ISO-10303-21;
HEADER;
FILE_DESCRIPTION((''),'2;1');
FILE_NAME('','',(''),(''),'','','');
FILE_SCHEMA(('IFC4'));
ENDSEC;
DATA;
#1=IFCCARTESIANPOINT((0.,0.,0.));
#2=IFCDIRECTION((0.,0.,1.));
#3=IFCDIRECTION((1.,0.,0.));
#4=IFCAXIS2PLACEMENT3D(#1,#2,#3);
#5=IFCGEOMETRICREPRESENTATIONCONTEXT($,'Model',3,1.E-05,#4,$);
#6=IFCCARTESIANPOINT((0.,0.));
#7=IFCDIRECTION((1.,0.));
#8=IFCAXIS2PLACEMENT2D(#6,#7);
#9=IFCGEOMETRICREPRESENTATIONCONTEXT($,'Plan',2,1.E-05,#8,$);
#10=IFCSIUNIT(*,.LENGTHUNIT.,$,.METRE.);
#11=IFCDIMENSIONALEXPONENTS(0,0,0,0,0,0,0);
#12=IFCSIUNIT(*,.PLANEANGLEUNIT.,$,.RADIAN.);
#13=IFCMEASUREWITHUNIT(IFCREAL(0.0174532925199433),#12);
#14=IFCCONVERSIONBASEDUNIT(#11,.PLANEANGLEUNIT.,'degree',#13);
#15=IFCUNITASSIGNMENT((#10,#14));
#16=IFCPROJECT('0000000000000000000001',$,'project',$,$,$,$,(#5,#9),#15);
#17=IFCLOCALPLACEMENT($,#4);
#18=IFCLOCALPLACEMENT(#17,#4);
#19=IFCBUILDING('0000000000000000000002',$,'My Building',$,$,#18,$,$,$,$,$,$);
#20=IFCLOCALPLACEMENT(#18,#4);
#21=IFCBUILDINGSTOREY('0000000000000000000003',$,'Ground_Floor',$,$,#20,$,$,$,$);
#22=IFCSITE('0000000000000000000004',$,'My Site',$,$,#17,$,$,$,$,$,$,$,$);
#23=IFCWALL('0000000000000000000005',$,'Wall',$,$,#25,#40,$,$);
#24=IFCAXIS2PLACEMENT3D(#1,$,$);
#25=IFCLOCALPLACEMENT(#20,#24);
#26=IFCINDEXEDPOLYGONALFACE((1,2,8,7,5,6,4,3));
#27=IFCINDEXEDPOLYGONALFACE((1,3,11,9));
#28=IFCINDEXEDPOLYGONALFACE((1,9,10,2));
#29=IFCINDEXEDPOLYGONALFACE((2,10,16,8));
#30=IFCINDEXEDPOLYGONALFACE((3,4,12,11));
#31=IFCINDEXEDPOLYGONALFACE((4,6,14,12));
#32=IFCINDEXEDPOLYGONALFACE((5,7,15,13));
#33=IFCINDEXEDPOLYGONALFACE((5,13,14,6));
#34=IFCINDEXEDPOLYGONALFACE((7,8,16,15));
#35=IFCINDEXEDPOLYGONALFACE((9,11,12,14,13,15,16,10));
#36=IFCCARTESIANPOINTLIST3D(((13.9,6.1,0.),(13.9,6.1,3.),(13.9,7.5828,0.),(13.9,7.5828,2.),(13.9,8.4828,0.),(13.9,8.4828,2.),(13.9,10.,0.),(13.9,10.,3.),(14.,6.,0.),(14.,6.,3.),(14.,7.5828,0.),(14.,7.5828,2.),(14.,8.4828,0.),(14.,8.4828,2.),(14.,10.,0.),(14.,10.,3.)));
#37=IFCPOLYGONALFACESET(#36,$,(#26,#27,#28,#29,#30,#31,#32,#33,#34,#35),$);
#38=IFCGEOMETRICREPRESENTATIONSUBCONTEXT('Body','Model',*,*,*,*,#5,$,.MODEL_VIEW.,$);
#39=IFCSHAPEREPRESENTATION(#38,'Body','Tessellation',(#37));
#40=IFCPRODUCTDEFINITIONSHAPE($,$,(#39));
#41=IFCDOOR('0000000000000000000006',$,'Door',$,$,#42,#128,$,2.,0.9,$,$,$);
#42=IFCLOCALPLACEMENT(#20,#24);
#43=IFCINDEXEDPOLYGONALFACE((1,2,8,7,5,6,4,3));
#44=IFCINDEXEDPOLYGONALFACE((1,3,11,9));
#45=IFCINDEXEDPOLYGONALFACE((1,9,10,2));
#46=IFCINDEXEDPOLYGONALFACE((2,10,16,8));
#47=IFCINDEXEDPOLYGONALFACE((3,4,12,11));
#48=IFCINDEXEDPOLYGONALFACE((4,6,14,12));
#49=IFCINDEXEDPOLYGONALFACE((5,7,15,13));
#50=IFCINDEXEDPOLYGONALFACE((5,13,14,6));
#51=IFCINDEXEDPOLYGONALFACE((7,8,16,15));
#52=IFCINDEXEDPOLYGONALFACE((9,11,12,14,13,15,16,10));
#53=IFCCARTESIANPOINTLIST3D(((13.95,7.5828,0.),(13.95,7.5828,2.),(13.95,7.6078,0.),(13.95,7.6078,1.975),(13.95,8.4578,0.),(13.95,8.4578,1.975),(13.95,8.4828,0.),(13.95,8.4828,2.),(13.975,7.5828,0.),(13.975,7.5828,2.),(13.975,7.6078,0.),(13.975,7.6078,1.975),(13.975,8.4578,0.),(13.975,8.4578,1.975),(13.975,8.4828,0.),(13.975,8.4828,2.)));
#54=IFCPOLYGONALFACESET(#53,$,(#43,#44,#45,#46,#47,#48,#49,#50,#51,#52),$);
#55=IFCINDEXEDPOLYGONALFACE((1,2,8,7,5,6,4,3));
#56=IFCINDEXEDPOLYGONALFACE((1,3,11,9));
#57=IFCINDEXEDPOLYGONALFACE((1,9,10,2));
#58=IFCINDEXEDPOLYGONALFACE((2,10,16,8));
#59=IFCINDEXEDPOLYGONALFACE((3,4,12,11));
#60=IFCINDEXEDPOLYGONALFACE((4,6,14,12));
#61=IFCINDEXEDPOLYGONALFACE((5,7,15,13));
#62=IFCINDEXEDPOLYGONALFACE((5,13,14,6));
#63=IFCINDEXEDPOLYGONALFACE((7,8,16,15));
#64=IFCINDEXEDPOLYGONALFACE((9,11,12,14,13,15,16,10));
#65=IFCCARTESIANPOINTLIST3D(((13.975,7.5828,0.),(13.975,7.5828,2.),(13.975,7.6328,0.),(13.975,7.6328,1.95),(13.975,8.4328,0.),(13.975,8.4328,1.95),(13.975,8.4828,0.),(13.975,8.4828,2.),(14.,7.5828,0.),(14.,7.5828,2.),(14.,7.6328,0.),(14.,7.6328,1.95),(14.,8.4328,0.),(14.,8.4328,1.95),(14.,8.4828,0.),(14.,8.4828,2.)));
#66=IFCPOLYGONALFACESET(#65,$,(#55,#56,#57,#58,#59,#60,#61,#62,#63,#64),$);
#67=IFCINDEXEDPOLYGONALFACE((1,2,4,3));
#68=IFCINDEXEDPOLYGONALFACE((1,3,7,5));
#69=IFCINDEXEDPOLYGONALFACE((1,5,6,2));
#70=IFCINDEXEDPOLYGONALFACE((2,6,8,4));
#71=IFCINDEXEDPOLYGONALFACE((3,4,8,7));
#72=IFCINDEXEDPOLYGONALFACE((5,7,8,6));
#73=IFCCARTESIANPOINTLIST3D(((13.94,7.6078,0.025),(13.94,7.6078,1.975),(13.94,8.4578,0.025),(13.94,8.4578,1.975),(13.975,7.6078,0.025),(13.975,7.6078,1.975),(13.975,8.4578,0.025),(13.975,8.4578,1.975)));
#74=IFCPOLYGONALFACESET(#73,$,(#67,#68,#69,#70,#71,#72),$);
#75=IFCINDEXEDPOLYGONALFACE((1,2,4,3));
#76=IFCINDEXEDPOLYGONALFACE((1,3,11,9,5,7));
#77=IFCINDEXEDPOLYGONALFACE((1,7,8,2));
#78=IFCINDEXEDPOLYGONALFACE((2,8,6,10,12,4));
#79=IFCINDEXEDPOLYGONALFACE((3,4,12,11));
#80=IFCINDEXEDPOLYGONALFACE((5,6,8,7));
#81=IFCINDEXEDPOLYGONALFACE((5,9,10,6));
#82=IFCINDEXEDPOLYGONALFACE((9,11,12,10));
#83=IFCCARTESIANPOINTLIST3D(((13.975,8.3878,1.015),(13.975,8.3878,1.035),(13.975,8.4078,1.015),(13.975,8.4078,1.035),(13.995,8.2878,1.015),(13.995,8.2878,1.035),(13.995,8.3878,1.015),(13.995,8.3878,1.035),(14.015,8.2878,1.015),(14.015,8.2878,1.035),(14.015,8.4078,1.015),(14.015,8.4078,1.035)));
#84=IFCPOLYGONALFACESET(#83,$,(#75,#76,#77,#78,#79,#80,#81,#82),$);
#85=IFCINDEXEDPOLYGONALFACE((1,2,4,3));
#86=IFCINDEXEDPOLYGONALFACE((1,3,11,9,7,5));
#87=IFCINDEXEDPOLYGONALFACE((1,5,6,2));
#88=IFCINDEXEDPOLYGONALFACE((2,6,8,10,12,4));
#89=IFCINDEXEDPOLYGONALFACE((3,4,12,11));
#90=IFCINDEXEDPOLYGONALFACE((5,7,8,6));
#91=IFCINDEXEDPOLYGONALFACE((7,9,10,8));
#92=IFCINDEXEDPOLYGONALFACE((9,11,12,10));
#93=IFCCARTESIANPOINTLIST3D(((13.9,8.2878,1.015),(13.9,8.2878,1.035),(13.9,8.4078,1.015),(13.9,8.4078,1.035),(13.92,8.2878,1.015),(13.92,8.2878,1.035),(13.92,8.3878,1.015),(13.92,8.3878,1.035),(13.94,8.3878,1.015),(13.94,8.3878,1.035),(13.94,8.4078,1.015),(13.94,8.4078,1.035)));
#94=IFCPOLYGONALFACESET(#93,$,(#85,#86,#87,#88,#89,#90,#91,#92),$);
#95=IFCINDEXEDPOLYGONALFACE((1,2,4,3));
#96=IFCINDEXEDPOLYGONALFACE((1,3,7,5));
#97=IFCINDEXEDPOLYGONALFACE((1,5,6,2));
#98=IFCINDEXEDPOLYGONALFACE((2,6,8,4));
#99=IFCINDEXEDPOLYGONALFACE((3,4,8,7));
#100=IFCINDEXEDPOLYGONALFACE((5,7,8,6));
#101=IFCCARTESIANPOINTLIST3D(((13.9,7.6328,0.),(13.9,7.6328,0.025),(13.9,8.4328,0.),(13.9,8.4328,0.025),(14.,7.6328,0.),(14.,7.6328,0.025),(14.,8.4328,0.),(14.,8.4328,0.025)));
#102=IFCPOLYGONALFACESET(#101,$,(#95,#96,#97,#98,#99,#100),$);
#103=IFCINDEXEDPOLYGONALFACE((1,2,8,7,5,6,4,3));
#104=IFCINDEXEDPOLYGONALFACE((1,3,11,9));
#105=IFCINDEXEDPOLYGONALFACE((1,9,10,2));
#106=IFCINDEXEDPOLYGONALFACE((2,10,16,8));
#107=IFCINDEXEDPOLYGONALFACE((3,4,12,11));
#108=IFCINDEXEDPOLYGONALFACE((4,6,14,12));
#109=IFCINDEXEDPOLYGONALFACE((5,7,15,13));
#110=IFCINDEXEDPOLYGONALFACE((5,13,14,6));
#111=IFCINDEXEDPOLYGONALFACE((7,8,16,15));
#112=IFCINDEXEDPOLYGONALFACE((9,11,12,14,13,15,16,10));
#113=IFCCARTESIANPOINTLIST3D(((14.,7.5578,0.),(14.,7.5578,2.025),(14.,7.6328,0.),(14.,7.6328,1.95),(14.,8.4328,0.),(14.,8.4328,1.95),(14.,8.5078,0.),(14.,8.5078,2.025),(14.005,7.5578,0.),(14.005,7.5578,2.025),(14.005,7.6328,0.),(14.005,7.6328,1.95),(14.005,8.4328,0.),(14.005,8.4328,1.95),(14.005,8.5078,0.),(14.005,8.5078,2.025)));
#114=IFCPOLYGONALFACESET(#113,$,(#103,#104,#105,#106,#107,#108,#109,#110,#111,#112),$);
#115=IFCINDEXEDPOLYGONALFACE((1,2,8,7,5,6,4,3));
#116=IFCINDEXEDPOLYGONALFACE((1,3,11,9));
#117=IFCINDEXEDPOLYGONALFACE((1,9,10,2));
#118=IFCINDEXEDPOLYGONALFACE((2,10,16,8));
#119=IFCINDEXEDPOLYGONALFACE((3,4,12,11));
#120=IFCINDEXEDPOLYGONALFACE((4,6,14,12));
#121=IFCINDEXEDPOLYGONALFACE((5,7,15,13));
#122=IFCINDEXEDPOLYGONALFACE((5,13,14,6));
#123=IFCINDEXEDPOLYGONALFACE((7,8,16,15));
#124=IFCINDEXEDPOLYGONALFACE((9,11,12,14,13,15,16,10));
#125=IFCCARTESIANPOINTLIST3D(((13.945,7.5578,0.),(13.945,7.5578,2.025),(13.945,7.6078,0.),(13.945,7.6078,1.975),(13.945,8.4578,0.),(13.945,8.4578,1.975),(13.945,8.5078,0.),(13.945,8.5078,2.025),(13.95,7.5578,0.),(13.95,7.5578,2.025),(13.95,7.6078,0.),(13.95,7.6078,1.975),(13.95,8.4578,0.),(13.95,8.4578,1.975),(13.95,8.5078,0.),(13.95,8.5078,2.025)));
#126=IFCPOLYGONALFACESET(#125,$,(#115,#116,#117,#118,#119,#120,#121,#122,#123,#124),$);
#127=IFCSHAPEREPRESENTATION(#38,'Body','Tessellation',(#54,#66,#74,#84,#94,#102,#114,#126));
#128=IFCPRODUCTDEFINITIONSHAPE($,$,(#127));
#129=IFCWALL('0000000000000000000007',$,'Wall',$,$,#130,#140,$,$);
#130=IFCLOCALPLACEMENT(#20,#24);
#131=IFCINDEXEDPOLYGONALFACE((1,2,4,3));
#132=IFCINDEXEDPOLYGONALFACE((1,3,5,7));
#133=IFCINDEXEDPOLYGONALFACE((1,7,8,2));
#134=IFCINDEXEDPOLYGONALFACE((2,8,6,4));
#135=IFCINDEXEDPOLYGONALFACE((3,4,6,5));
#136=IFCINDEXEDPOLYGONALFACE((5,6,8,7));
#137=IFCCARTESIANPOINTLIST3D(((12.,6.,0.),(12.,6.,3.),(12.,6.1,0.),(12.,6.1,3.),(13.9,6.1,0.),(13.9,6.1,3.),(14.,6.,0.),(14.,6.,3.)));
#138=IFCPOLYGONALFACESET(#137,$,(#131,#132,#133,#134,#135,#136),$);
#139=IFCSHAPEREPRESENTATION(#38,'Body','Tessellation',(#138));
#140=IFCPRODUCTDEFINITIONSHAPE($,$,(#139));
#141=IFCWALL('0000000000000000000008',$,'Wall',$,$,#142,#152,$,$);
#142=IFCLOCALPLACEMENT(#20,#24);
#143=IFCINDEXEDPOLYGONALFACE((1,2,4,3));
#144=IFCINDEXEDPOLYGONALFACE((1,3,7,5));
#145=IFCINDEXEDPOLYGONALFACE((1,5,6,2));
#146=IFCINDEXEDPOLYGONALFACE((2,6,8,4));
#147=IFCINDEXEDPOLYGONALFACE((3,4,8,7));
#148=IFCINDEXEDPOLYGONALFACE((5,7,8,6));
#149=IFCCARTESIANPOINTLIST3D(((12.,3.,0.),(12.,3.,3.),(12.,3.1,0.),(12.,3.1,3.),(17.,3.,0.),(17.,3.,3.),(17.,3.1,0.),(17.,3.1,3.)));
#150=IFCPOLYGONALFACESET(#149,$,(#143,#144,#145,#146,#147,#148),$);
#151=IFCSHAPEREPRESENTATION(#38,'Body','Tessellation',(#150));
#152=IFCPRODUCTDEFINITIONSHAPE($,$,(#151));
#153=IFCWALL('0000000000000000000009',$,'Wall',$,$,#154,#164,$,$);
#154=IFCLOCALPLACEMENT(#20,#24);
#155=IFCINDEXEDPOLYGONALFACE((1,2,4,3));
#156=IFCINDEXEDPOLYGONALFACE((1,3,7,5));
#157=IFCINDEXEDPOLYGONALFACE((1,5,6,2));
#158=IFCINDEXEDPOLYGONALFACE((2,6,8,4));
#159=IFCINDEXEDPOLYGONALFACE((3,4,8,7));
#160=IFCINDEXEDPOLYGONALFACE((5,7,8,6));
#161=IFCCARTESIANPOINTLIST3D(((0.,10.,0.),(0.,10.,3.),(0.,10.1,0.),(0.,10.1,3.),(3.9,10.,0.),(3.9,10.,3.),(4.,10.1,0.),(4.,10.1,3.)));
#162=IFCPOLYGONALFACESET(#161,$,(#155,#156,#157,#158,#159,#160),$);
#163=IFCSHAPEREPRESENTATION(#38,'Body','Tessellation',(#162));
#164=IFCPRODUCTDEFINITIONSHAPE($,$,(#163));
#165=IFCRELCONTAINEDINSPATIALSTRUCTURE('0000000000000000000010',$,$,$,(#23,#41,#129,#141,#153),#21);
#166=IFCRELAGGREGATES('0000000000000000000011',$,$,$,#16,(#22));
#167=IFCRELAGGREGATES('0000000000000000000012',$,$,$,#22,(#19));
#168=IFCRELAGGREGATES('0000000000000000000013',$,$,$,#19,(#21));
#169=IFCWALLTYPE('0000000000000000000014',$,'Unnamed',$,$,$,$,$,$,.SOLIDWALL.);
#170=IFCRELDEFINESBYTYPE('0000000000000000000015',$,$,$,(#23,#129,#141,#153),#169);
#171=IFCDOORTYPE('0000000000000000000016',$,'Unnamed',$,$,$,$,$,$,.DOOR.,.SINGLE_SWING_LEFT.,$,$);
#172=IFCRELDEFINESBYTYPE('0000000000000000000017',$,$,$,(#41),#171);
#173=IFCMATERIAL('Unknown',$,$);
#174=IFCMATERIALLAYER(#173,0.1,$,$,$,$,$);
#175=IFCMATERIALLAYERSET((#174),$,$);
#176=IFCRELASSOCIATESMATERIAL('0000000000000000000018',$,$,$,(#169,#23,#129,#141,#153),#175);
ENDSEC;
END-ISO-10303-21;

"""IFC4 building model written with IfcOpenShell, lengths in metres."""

from ifc_helpers import new_model, entity, si_unit, converted_unit, frame, origin_with_axes, origin_2d_with_axis, place, context, subcontext, project, spatial, line, indexed_curve, outline, extrude, shape, source, transform, mapped, material, layer, layer_set, layer_usage, type_object, type_shapes, element, fill, save


model = new_model("IFC4")

# Units and contexts
model_context = context("Model", 3, precision=1e-05, world=origin_with_axes())
plan_context = context("Plan", 2, precision=1e-05, world=origin_2d_with_axis())
body_context_1 = subcontext(model_context, "Body", "Model", "MODEL_VIEW")
body_context_2 = subcontext(plan_context, "Body", "Plan", "PLAN_VIEW")
ifc_project = project(units=[si_unit("LENGTHUNIT", "METRE"), converted_unit("PLANEANGLEUNIT", "degree", entity("IfcReal", 0.0174532925199433), si_unit("PLANEANGLEUNIT", "RADIAN"), dimensions=[0, 0, 0, 0, 0, 0, 0])], contexts=[model_context, plan_context])

# Site, building, storey
site_placement = place(None, origin_with_axes())
site = spatial("IfcSite", under=ifc_project, at=site_placement, Name="My Site")
building_placement = place(site_placement, origin_with_axes())
building = spatial("IfcBuilding", under=site, at=building_placement, Name="My Building")
storey_placement = place(building_placement, origin_with_axes())
storey = spatial("IfcBuildingStorey", under=building, at=storey_placement, Name="Ground_Floor")

# Shared definitions
ifc_material = material(Name="Unknown")
ifc_layer = layer(ifc_material, 0.1)
ifc_layer_set = layer_set([ifc_layer])
wall_type = type_object("IfcWallType", Name="Unnamed", PredefinedType="SOLIDWALL", material=ifc_layer_set)

# Wall, opening, door
shared_shape_1 = source(origin_with_axes(), body_context_1, "Body", "SweptSolid", [
    extrude(outline(indexed_curve([(0.0, 0.0), (0.9, 0.0), (0.9, 2.0), (0.0, 2.0)], segments=[line(1, 2, 3, 4, 1)])), frame((0.0, -0.6, 0.0), z_axis=(0.0, -1.0, 0.0), x_axis=(1.0, 0.0, 0.0)), (0.0, 0.0, -1.0), 1.2),
])
door_type_1 = type_object("IfcDoorType", Name="Unnamed", OperationType="SINGLE_SWING_LEFT", PredefinedType="DOOR")
shared_shape_2 = source(origin_with_axes(), body_context_1, "Body", "SweptSolid", [
    extrude(outline(indexed_curve([(0.0, 0.0), (0.0, 2.0), (0.9, 2.0), (0.9, 0.0), (0.875, 0.0), (0.875, 1.975), (0.025, 1.975), (0.025, 0.0)], segments=[line(1, 2, 3, 4, 5, 6, 7, 8, 1)])), frame((0.0, 0.025, 0.0), z_axis=(0.0, -1.0, 0.0), x_axis=(1.0, 0.0, 0.0)), (0.0, 0.0, -1.0), 0.025),
    extrude(outline(indexed_curve([(0.0, 0.0), (0.0, 2.0), (0.9, 2.0), (0.9, 0.0), (0.85, 0.0), (0.85, 1.95), (0.05, 1.95), (0.05, 0.0)], segments=[line(1, 2, 3, 4, 5, 6, 7, 8, 1)])), frame((0.0, 0.0, 0.0), z_axis=(0.0, -1.0, 0.0), x_axis=(1.0, 0.0, 0.0)), (0.0, 0.0, -1.0), 0.025),
    extrude(outline(indexed_curve([(0.0, 0.0), (0.85, 0.0), (0.85, 0.035), (0.0, 0.035)], segments=[line(1, 2, 3, 4, 1)])), frame((0.025, 0.025, 0.025), z_axis=(0.0, 0.0, 1.0), x_axis=(1.0, 0.0, 0.0)), (0.0, 0.0, 1.0), 1.95),
    extrude(outline(indexed_curve([(0.0, 0.0), (0.0, -0.04), (-0.12, -0.04), (-0.12, -0.02), (-0.02, -0.02), (-0.02, 0.0)], segments=[line(1, 2, 3, 4, 5, 6, 1)])), frame((0.825, 0.025, 1.015), z_axis=(0.0, 0.0, 1.0), x_axis=(1.0, 0.0, 0.0)), (0.0, 0.0, 1.0), 0.02),
    extrude(outline(indexed_curve([(0.0, 0.0), (0.0, 0.04), (-0.12, 0.04), (-0.12, 0.02), (-0.02, 0.02), (-0.02, 0.0)], segments=[line(1, 2, 3, 4, 5, 6, 1)])), frame((0.825, 0.06, 1.015), z_axis=(0.0, 0.0, 1.0), x_axis=(1.0, 0.0, 0.0)), (0.0, 0.0, 1.0), 0.02),
    extrude(outline(indexed_curve([(0.0, 0.0), (0.8, 0.0), (0.8, 0.1), (0.0, 0.1)], segments=[line(1, 2, 3, 4, 1)])), frame((0.05, 0.0, 0.0), z_axis=(0.0, 0.0, 1.0), x_axis=(1.0, 0.0, 0.0)), (0.0, 0.0, 1.0), 0.025),
    extrude(outline(indexed_curve([(0.0, 0.0), (0.0, 2.025), (0.95, 2.025), (0.95, 0.0), (0.875, 0.0), (0.875, 1.95), (0.075, 1.95), (0.075, 0.0)], segments=[line(1, 2, 3, 4, 5, 6, 7, 8, 1)])), frame((-0.025, -0.005, 0.0), z_axis=(0.0, -1.0, 0.0), x_axis=(1.0, 0.0, 0.0)), (0.0, 0.0, -1.0), 0.005),
    extrude(outline(indexed_curve([(0.0, 0.0), (0.0, 2.025), (0.95, 2.025), (0.95, 0.0), (0.9, 0.0), (0.9, 1.975), (0.05, 1.975), (0.05, 0.0)], segments=[line(1, 2, 3, 4, 5, 6, 7, 8, 1)])), frame((-0.025, 0.05, 0.0), z_axis=(0.0, -1.0, 0.0), x_axis=(1.0, 0.0, 0.0)), (0.0, 0.0, -1.0), 0.005),
])
shared_shape_3 = source(origin_with_axes(), body_context_2, "Body", "Curve2D", [
    entity("IfcIndexedPolyCurve", entity("IfcCartesianPointList2D", [[0.0, 0.0], [0.0, 0.05], [0.025, 0.05], [0.025, 0.025], [0.05, 0.025], [0.05, 0.0]]), [entity("IfcLineIndex", [1, 2, 3, 4, 5, 6, 1])]),
    entity("IfcIndexedPolyCurve", entity("IfcCartesianPointList2D", [[0.9, 0.0], [0.9, 0.05], [0.875, 0.05], [0.875, 0.025], [0.85, 0.025], [0.85, 0.0]]), [entity("IfcLineIndex", [1, 2, 3, 4, 5, 6, 1])]),
    entity("IfcTrimmedCurve", entity("IfcEllipse", entity("IfcAxis2Placement2D", entity("IfcCartesianPoint", [0.06, 0.05]), entity("IfcDirection", [1.0, 0.0])), 0.815, 0.85), [entity("IfcCartesianPoint", [0.875, 0.05])], [entity("IfcCartesianPoint", [0.06, 0.9])], True, "CARTESIAN"),
    entity("IfcIndexedPolyCurve", entity("IfcCartesianPointList2D", [[0.025, 0.05], [0.06, 0.05], [0.06, 0.9], [0.025, 0.9]]), [entity("IfcLineIndex", [1, 2, 3, 4, 1])]),
])
type_shapes(door_type_1, [shared_shape_2, shared_shape_3])
ifc_layer_usage_1 = layer_usage(ifc_layer_set, "AXIS2", "POSITIVE", 0.0)
wall_1_placement = place(storey_placement, frame((14.0, 6.0, 0.0), z_axis=(0.0, 0.0, 1.0), x_axis=(0.0, 1.0, 0.0)))
wall_1 = element("IfcWall", 1, at=wall_1_placement, inside=storey, type_object=wall_type, material=ifc_layer_usage_1, Name="Wall", context=body_context_1, shape_type="SweptSolid", body=[
    extrude(outline(indexed_curve([(0.0, 0.0), (0.1, 0.1), (4.0, 0.1), (4.0, 0.0)], segments=[line(1, 2, 3, 4, 1)])), origin_with_axes(), (0.0, 0.0, 1.0), 3.0),
])
opening_1_placement = place(wall_1_placement, frame((1.5828, 0.0, 0.0), z_axis=(0.0, 0.0, 1.0), x_axis=(1.0, 0.0, 0.0)))
opening_1 = element("IfcOpeningElement", 2, at=opening_1_placement, cuts=wall_1, PredefinedType="OPENING", context=body_context_1, shape_type="MappedRepresentation", body=[
    mapped(shared_shape_1, transform((0.0, 0.0, 0.0), x_axis=(1.0, 0.0, 0.0), y_axis=(0.0, 1.0, 0.0), z_axis=(0.0, 0.0, 1.0), scale=1.0)),
])
door_1_placement = place(opening_1_placement, frame((0.0, 0.0, 0.0), z_axis=(0.0, 0.0, 1.0), x_axis=(1.0, 0.0, 0.0)))
door_1 = element("IfcDoor", 3, at=door_1_placement, inside=storey, type_object=door_type_1, Name="Door", OverallHeight=2.0, OverallWidth=0.9, shapes=[
    shape(body_context_1, "Body", "MappedRepresentation", [mapped(shared_shape_2, transform((0.0, 0.0, 0.0), x_axis=(1.0, 0.0, 0.0), y_axis=(0.0, 1.0, 0.0), z_axis=(0.0, 0.0, 1.0), scale=1.0))]),
    shape(body_context_2, "Body", "MappedRepresentation", [mapped(shared_shape_3, transform((0.0, 0.0, 0.0), x_axis=(1.0, 0.0, 0.0), y_axis=(0.0, 1.0, 0.0), z_axis=(0.0, 0.0, 1.0), scale=1.0))]),
])
fill(opening_1, door_1)

# Walls
ifc_layer_usage_2 = layer_usage(ifc_layer_set, "AXIS2", "POSITIVE", 0.0)
wall_2_placement = place(storey_placement, frame((12.0, 6.0, 0.0), z_axis=(0.0, 0.0, 1.0), x_axis=(1.0, 0.0, 0.0)))
element("IfcWall", 4, at=wall_2_placement, inside=storey, type_object=wall_type, material=ifc_layer_usage_2, Name="Wall", context=body_context_1, shape_type="SweptSolid", body=[
    extrude(outline(indexed_curve([(0.0, 0.0), (0.0, 0.1), (1.9, 0.1), (2.0, 0.0)], segments=[line(1, 2, 3, 4, 1)])), origin_with_axes(), (0.0, 0.0, 1.0), 3.0),
])
ifc_layer_usage_3 = layer_usage(ifc_layer_set, "AXIS2", "POSITIVE", 0.0)
wall_3_placement = place(storey_placement, frame((12.0, 3.0, 0.0), z_axis=(0.0, 0.0, 1.0), x_axis=(1.0, 0.0, 0.0)))
element("IfcWall", 5, at=wall_3_placement, inside=storey, type_object=wall_type, material=ifc_layer_usage_3, Name="Wall", context=body_context_1, shape_type="SweptSolid", body=[
    extrude(outline(indexed_curve([(0.0, 0.0), (0.0, 0.1), (5.0, 0.1), (5.0, 0.0)], segments=[line(1, 2, 3, 4, 1)])), origin_with_axes(), (0.0, 0.0, 1.0), 3.0),
])

# Wall
ifc_layer_usage_4 = layer_usage(ifc_layer_set, "AXIS2", "POSITIVE", 0.0)
wall_4_placement = place(storey_placement, frame((4.0, 10.1, 0.0), z_axis=(0.0, 0.0, 1.0), x_axis=(-1.0, 0.0, 0.0)))
element("IfcWall", 6, at=wall_4_placement, inside=storey, type_object=wall_type, material=ifc_layer_usage_4, Name="Wall", context=body_context_1, shape_type="SweptSolid", body=[
    extrude(outline(indexed_curve([(0.0, 0.0), (0.1, 0.1), (4.0, 0.1), (4.0, 0.0)], segments=[line(1, 2, 3, 4, 1)])), origin_with_axes(), (0.0, 0.0, 1.0), 3.0),
])

save(model, "model.ifc")
